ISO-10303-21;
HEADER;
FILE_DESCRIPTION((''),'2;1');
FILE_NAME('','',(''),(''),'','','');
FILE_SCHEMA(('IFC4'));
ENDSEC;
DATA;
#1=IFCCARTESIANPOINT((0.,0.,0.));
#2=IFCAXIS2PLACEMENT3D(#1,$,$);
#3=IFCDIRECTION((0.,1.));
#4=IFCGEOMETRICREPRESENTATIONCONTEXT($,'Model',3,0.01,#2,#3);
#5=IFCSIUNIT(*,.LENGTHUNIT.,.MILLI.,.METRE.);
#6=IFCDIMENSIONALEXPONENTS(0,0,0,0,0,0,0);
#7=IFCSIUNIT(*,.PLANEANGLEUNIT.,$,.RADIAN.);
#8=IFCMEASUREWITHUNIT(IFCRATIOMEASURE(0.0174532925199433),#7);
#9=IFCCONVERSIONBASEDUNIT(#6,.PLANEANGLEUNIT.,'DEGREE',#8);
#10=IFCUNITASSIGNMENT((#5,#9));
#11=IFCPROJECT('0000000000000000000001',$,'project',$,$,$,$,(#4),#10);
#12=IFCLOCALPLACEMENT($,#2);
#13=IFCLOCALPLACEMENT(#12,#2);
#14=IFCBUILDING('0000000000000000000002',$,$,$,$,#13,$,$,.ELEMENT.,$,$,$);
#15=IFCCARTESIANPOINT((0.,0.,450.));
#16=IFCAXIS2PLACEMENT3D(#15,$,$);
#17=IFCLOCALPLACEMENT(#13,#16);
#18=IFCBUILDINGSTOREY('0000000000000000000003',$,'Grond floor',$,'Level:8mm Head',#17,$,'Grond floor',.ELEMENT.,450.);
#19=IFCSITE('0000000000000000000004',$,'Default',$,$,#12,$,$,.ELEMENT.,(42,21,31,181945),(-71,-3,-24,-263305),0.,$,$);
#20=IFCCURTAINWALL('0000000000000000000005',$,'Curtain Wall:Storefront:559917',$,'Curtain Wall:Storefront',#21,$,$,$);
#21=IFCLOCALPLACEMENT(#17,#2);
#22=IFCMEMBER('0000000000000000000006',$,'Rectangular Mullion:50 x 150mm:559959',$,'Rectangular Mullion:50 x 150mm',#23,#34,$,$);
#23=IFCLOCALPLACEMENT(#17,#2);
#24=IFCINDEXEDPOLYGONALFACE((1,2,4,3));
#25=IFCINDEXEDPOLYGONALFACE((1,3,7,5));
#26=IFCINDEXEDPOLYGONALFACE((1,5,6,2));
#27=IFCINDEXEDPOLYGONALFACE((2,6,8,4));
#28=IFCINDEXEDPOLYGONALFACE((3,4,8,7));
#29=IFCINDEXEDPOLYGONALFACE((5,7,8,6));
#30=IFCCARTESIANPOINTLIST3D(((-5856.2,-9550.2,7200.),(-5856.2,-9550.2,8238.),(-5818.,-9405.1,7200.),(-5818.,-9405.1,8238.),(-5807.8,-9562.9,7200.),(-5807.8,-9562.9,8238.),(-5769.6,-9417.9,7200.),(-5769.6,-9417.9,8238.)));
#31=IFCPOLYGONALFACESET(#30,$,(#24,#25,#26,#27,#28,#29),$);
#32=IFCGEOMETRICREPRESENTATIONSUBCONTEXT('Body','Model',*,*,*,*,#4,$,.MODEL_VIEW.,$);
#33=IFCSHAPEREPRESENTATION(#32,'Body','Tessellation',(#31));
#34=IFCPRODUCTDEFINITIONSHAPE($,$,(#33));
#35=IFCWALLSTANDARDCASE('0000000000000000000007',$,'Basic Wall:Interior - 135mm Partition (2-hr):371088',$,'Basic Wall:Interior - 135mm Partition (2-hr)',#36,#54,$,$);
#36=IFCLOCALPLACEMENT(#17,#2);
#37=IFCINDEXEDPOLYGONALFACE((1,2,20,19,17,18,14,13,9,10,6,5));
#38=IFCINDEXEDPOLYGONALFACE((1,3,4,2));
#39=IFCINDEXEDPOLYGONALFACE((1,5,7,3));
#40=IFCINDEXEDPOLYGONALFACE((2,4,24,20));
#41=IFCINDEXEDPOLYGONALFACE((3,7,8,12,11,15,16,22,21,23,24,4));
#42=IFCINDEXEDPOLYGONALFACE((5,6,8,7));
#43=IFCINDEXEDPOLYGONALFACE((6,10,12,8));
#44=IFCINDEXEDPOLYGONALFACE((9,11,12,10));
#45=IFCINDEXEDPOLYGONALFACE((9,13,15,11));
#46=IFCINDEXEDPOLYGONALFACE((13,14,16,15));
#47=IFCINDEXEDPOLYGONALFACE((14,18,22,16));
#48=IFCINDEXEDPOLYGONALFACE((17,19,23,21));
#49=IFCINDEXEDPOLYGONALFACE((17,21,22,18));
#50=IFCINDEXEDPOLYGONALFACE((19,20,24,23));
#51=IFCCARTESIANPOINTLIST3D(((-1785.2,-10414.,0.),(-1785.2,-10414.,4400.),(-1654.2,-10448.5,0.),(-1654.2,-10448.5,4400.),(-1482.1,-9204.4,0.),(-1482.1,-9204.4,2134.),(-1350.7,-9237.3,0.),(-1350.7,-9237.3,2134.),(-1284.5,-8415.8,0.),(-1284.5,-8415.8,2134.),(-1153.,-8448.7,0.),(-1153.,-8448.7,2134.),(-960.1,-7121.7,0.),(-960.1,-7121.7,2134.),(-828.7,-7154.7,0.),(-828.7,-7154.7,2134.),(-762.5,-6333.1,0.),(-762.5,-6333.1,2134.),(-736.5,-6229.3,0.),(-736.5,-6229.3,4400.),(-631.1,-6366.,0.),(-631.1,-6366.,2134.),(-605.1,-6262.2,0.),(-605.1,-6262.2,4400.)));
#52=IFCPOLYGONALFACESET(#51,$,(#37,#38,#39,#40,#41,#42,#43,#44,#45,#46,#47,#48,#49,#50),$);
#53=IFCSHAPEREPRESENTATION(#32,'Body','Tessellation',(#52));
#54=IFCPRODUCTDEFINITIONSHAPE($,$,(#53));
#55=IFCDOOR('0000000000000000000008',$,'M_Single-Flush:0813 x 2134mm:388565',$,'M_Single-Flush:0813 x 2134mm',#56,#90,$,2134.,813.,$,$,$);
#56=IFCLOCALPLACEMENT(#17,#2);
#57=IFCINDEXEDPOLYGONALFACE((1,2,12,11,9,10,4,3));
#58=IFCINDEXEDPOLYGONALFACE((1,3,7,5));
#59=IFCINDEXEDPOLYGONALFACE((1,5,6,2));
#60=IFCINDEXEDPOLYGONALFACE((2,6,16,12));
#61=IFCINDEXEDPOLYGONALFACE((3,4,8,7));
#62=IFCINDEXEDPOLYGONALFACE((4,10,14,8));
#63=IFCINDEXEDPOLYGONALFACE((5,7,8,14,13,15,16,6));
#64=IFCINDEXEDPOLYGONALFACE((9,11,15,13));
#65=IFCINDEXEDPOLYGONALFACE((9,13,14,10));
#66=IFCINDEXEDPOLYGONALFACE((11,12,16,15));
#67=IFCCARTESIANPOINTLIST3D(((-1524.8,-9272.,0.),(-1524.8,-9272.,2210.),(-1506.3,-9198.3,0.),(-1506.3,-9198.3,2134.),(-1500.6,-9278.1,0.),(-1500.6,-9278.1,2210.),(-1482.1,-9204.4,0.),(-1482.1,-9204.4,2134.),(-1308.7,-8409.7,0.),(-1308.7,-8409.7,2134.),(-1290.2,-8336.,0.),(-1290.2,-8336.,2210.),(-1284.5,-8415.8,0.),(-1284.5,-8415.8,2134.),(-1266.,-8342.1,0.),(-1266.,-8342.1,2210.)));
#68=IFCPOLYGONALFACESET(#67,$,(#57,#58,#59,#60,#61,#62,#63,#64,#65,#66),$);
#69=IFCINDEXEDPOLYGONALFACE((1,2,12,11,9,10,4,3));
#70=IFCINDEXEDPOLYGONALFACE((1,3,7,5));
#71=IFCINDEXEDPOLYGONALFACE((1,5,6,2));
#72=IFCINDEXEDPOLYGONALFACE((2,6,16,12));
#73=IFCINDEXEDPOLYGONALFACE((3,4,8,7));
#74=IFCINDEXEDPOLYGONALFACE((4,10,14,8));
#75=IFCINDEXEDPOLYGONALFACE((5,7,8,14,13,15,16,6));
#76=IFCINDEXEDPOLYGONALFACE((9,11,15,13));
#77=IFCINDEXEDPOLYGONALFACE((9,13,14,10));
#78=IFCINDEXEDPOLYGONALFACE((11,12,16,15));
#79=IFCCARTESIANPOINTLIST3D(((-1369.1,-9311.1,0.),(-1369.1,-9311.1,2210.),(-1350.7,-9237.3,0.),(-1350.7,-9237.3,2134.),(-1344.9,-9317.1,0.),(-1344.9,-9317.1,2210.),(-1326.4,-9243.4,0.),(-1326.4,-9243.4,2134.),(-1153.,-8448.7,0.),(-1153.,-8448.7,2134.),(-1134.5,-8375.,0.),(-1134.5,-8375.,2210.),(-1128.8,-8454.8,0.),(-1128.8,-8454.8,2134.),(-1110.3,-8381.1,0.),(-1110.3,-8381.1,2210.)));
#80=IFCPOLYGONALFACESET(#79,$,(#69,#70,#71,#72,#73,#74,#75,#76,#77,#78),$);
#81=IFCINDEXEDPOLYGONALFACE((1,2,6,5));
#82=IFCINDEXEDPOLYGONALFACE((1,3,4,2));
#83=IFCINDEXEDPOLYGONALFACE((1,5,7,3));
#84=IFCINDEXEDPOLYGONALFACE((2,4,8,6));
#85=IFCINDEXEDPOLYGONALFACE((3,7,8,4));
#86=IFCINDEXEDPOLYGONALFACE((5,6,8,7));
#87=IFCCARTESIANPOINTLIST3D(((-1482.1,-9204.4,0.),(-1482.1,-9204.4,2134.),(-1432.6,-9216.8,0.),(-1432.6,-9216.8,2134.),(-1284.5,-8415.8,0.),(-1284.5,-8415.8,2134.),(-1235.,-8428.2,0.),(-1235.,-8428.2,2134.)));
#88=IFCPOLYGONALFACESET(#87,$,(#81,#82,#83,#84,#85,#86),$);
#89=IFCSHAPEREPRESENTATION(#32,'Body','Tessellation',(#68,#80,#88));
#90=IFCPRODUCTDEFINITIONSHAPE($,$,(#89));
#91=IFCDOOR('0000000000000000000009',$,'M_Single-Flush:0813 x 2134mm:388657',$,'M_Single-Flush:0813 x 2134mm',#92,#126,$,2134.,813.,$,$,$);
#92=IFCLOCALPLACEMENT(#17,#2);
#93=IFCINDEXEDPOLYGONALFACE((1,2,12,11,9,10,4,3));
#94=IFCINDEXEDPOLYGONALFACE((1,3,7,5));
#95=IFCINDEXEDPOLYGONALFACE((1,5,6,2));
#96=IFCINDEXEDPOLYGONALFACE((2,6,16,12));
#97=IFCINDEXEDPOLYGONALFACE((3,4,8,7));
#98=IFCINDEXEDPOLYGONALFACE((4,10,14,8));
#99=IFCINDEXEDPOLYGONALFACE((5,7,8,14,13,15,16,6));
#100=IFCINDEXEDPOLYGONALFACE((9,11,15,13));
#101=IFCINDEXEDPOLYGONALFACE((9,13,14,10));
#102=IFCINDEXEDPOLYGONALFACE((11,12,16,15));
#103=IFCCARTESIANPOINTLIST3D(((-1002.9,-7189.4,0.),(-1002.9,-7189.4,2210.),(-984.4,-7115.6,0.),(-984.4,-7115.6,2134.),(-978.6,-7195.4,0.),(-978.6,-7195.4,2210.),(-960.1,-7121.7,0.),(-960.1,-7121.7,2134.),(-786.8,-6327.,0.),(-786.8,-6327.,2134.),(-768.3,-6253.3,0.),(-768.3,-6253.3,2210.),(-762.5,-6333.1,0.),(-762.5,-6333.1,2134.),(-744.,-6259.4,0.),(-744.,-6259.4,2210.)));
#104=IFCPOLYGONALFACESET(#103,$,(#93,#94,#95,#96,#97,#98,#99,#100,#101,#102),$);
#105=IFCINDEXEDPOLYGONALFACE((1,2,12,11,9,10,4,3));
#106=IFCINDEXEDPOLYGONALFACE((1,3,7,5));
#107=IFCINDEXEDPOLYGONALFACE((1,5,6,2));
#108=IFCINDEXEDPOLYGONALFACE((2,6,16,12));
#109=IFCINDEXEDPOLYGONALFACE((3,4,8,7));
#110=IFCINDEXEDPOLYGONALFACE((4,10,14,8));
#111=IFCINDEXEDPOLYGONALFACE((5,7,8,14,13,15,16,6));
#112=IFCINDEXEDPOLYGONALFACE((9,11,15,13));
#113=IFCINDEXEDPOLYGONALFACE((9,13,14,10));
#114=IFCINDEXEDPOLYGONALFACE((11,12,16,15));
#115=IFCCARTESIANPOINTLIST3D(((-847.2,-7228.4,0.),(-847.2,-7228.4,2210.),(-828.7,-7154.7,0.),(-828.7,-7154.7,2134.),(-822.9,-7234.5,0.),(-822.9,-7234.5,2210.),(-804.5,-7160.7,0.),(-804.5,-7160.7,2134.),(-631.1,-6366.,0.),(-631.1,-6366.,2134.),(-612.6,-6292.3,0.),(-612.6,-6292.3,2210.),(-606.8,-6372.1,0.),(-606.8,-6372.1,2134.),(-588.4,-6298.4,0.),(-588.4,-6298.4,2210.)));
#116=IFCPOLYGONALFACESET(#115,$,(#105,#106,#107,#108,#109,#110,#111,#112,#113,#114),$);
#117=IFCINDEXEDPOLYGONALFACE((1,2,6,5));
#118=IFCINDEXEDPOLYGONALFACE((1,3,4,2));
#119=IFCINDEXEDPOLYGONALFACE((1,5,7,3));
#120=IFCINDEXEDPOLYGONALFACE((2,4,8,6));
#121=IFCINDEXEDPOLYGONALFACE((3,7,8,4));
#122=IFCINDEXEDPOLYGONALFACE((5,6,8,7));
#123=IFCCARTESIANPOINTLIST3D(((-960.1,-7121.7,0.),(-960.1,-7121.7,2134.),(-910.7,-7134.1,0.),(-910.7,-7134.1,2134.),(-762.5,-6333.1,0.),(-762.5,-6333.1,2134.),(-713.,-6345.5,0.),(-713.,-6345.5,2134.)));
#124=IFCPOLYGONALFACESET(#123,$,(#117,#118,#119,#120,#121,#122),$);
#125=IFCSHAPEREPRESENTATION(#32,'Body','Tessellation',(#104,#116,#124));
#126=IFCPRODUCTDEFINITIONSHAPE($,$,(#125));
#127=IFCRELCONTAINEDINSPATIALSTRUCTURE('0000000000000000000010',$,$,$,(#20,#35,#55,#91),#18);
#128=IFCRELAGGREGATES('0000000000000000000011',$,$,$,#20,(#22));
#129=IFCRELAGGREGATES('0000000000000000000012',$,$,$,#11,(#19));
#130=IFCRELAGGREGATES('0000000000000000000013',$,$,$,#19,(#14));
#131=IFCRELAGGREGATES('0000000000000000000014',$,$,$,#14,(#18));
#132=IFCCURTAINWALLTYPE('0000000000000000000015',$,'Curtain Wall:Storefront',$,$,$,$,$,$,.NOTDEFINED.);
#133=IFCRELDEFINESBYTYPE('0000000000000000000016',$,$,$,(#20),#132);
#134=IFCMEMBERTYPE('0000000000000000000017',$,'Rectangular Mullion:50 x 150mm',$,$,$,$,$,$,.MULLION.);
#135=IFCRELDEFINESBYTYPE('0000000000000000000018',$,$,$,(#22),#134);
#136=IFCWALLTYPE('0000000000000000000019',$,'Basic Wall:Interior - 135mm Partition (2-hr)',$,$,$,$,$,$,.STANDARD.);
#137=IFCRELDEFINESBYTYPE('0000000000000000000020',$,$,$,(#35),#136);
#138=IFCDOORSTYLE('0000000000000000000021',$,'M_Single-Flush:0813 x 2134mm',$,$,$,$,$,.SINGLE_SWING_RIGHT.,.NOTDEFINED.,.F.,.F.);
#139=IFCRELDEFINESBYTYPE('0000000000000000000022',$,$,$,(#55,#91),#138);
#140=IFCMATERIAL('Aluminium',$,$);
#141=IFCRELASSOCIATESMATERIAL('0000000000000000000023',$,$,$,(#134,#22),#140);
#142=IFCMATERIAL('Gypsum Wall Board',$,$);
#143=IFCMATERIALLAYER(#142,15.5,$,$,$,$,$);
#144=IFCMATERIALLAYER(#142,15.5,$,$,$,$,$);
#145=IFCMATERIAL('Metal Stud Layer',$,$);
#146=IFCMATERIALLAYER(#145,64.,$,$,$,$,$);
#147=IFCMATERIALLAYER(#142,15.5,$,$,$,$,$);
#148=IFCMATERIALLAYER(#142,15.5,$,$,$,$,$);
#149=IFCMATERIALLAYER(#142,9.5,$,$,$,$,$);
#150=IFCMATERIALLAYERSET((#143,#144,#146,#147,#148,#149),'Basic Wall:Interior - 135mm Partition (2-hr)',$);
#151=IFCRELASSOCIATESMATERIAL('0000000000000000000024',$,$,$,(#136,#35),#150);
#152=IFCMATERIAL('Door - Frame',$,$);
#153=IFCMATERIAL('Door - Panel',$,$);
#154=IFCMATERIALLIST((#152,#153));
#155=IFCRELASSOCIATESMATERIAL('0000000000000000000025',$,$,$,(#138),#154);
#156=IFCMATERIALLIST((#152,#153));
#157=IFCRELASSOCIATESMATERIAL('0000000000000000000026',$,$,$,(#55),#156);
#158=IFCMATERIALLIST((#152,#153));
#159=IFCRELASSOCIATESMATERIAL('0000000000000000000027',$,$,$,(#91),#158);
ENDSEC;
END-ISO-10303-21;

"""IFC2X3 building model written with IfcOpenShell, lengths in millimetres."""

from ifc_helpers import new_model, entity, si_unit, converted_unit, direction, frame, frame_2d, origin, origin_2d_with_axis, place, context, subcontext, project, spatial, polyline, rectangle, outline, extrude, source, transform, mapped, material, material_list, layer, layer_set, layer_usage, type_object, type_shapes, element, fill, aggregate, save


model = new_model("IFC2X3")

# Units and contexts
model_context = context("Model", 3, precision=0.01, world=origin(), true_north=direction((0.0, 1.0)))
body_context = subcontext(model_context, "Body", "Model", "MODEL_VIEW")
ifc_project = project(units=[si_unit("LENGTHUNIT", "METRE", prefix="MILLI"), converted_unit("PLANEANGLEUNIT", "DEGREE", entity("IfcRatioMeasure", 0.0174532925199433), si_unit("PLANEANGLEUNIT", "RADIAN"), dimensions=[0, 0, 0, 0, 0, 0, 0])], contexts=[model_context])

# Site, building, storey
site_placement = place(None, origin())
site = spatial("IfcSite", under=ifc_project, at=site_placement, Name="Default", CompositionType="ELEMENT", RefLatitude=(42, 21, 31, 181945), RefLongitude=(-71, -3, -24, -263305), RefElevation=0.0)
building_placement = place(site_placement, origin())
building = spatial("IfcBuilding", under=site, at=building_placement, CompositionType="ELEMENT")
storey_placement = place(building_placement, frame((0.0, 0.0, 450.0)))
storey = spatial("IfcBuildingStorey", under=building, at=storey_placement, Name="Grond floor", ObjectType="Level:8mm Head", LongName="Grond floor", CompositionType="ELEMENT", Elevation=450.0)

# Curtain wall, member
curtain_wall_type = type_object("IfcCurtainWallType", Name="Curtain Wall:Storefront", PredefinedType="NOTDEFINED")
curtain_wall_placement = place(storey_placement, frame((0.0, 0.0, -450.0)))
curtain_wall = element("IfcCurtainWall", 1, at=curtain_wall_placement, inside=storey, type_object=curtain_wall_type, Name="Curtain Wall:Storefront:559917", ObjectType="Curtain Wall:Storefront")
ifc_material_1 = material(Name="Aluminium")
member_type = type_object("IfcMemberType", Name="Rectangular Mullion:50 x 150mm", PredefinedType="MULLION", material=ifc_material_1)
shared_shape_1 = source(origin(), body_context, "Body", "SweptSolid", [
    extrude(rectangle(XDim=150.0, YDim=50.0, at=origin_2d_with_axis()), frame((-25.0, 0.0, -1038.0), z_axis=(0.0, 0.0, 1.0), x_axis=(0.0, -1.0, 0.0)), (0.0, 0.0, 1.0), 1038.0),
])
type_shapes(member_type, [shared_shape_1])
member_placement = place(storey_placement, frame((-5788.7, -9490.4, 7200.0), z_axis=(0.0, 0.0, -1.0), x_axis=(0.967067, -0.25452, 0.0)))
member = element("IfcMember", 2, at=member_placement, type_object=member_type, material=ifc_material_1, Name="Rectangular Mullion:50 x 150mm:559959", ObjectType="Rectangular Mullion:50 x 150mm", context=body_context, shape_type="MappedRepresentation", body=[
    mapped(shared_shape_1, transform((0.0, 0.0, 0.0), scale=1.0)),
])
aggregate(curtain_wall, [member])

# Shared definitions
ifc_material_2 = material(Name="Gypsum Wall Board")
ifc_layer_1 = layer(ifc_material_2, 15.5)
ifc_layer_2 = layer(ifc_material_2, 15.5)
ifc_material_3 = material(Name="Metal Stud Layer")
ifc_layer_3 = layer(ifc_material_3, 64.0)
ifc_layer_4 = layer(ifc_material_2, 15.5)
ifc_layer_5 = layer(ifc_material_2, 15.5)
ifc_layer_6 = layer(ifc_material_2, 9.5)
ifc_layer_set = layer_set([ifc_layer_1, ifc_layer_2, ifc_layer_3, ifc_layer_4, ifc_layer_5, ifc_layer_6], Name="Basic Wall:Interior - 135mm Partition (2-hr)")
wall_type = type_object("IfcWallType", Name="Basic Wall:Interior - 135mm Partition (2-hr)", PredefinedType="STANDARD", material=ifc_layer_set)

# Wall, openings, doors
ifc_layer_usage_1 = layer_usage(ifc_layer_set, "AXIS2", "NEGATIVE", 67.8)
wall_1_placement = place(storey_placement, frame((-1719.9, -10432.0, 0.0), z_axis=(0.0, 0.0, 1.0), x_axis=(0.243092, 0.970003, 0.0)))
wall_1 = element("IfcWallStandardCase", 3, at=wall_1_placement, inside=storey, type_object=wall_type, material=ifc_layer_usage_1, Name="Basic Wall:Interior - 135mm Partition (2-hr):371088", ObjectType="Basic Wall:Interior - 135mm Partition (2-hr)", context=body_context, shape_type="SweptSolid", body=[
    extrude(outline(polyline([(0.0, -67.8), (4315.7, -67.8), (4315.7, 67.8), (2348.1, 67.8), (2212.6, 67.8), (1.6, 67.7), (0.0, -67.8)])), origin(), (0.0, 0.0, 1.0), 4400.0),
])
opening_1_placement = place(wall_1_placement, frame((1248.6, -67.8, 0.0)))
opening_1 = element("IfcOpeningElement", 4, at=opening_1_placement, cuts=wall_1, ObjectType="Opening", context=body_context, shape_type="SweptSolid", body=[
    extrude(rectangle(XDim=813.0, YDim=2134.0, at=frame_2d((1067.0, 406.5), x_axis=(0.0, 1.0))), frame((0.0, 0.0, 0.0), z_axis=(0.0, 1.0, 0.0), x_axis=(0.0, 0.0, 1.0)), (0.0, 0.0, 1.0), 135.5),
])
opening_2_placement = place(wall_1_placement, frame((3395.7, -67.8, 0.0)))
opening_2 = element("IfcOpeningElement", 5, at=opening_2_placement, cuts=wall_1, ObjectType="Opening", context=body_context, shape_type="SweptSolid", body=[
    extrude(rectangle(XDim=813.0, YDim=2134.0, at=frame_2d((1067.0, 406.5), x_axis=(0.0, 1.0))), frame((0.0, 0.0, 0.0), z_axis=(0.0, 1.0, 0.0), x_axis=(0.0, 0.0, 1.0)), (0.0, 0.0, 1.0), 135.5),
])
ifc_material_4 = material(Name="Door - Frame")
ifc_material_5 = material(Name="Door - Panel")
ifc_material_list_1 = material_list([ifc_material_4, ifc_material_5])
ifc_material_list_2 = material_list([ifc_material_4, ifc_material_5])
door_style_1 = type_object("IfcDoorStyle", Name="M_Single-Flush:0813 x 2134mm", ConstructionType="NOTDEFINED", OperationType="SINGLE_SWING_RIGHT", ParameterTakesPrecedence=False, Sizeable=False, material=ifc_material_list_2)
shared_shape_2 = source(origin(), body_context, "Body", "SweptSolid", [
    extrude(outline(polyline([(-482.5, -1124.0), (482.5, -1124.0), (482.5, 1086.0), (406.5, 1086.0), (406.5, -1048.0), (-406.5, -1048.0), (-406.5, 1086.0), (-482.5, 1086.0), (-482.5, -1124.0)])), frame((406.5, 135.5, 1086.0), z_axis=(0.0, 1.0, 0.0), x_axis=(1.0, 0.0, 0.0)), (0.0, 0.0, 1.0), 25.0),
    extrude(outline(polyline([(-1124.0, -482.5), (1086.0, -482.5), (1086.0, -406.5), (-1048.0, -406.5), (-1048.0, 406.5), (1086.0, 406.5), (1086.0, 482.5), (-1124.0, 482.5), (-1124.0, -482.5)])), frame((406.5, -25.0, 1086.0), z_axis=(0.0, 1.0, 0.0), x_axis=(0.0, 0.0, -1.0)), (0.0, 0.0, 1.0), 25.0),
    extrude(rectangle(XDim=51.0, YDim=813.0, at=frame_2d((0.0, 0.0), x_axis=(1.0, 0.0))), frame((406.5, 110.0, 0.0), z_axis=(0.0, 0.0, 1.0), x_axis=(0.0, 1.0, 0.0)), (0.0, 0.0, 1.0), 2134.0),
])
type_shapes(door_style_1, [shared_shape_2])
door_1_placement = place(opening_1_placement, origin())
door_1 = element("IfcDoor", 6, at=door_1_placement, inside=storey, type_object=door_style_1, material=ifc_material_list_1, Name="M_Single-Flush:0813 x 2134mm:388565", ObjectType="M_Single-Flush:0813 x 2134mm", OverallHeight=2134.0, OverallWidth=813.0, context=body_context, shape_type="MappedRepresentation", body=[
    mapped(shared_shape_2, transform((0.0, 0.0, 0.0), scale=1.0)),
])
fill(opening_1, door_1)
ifc_material_list_3 = material_list([ifc_material_4, ifc_material_5])
door_2_placement = place(opening_2_placement, origin())
door_2 = element("IfcDoor", 7, at=door_2_placement, inside=storey, type_object=door_style_1, material=ifc_material_list_3, Name="M_Single-Flush:0813 x 2134mm:388657", ObjectType="M_Single-Flush:0813 x 2134mm", OverallHeight=2134.0, OverallWidth=813.0, context=body_context, shape_type="MappedRepresentation", body=[
    mapped(shared_shape_2, transform((0.0, 0.0, 0.0), scale=1.0)),
])
fill(opening_2, door_2)

save(model, "model.ifc")
